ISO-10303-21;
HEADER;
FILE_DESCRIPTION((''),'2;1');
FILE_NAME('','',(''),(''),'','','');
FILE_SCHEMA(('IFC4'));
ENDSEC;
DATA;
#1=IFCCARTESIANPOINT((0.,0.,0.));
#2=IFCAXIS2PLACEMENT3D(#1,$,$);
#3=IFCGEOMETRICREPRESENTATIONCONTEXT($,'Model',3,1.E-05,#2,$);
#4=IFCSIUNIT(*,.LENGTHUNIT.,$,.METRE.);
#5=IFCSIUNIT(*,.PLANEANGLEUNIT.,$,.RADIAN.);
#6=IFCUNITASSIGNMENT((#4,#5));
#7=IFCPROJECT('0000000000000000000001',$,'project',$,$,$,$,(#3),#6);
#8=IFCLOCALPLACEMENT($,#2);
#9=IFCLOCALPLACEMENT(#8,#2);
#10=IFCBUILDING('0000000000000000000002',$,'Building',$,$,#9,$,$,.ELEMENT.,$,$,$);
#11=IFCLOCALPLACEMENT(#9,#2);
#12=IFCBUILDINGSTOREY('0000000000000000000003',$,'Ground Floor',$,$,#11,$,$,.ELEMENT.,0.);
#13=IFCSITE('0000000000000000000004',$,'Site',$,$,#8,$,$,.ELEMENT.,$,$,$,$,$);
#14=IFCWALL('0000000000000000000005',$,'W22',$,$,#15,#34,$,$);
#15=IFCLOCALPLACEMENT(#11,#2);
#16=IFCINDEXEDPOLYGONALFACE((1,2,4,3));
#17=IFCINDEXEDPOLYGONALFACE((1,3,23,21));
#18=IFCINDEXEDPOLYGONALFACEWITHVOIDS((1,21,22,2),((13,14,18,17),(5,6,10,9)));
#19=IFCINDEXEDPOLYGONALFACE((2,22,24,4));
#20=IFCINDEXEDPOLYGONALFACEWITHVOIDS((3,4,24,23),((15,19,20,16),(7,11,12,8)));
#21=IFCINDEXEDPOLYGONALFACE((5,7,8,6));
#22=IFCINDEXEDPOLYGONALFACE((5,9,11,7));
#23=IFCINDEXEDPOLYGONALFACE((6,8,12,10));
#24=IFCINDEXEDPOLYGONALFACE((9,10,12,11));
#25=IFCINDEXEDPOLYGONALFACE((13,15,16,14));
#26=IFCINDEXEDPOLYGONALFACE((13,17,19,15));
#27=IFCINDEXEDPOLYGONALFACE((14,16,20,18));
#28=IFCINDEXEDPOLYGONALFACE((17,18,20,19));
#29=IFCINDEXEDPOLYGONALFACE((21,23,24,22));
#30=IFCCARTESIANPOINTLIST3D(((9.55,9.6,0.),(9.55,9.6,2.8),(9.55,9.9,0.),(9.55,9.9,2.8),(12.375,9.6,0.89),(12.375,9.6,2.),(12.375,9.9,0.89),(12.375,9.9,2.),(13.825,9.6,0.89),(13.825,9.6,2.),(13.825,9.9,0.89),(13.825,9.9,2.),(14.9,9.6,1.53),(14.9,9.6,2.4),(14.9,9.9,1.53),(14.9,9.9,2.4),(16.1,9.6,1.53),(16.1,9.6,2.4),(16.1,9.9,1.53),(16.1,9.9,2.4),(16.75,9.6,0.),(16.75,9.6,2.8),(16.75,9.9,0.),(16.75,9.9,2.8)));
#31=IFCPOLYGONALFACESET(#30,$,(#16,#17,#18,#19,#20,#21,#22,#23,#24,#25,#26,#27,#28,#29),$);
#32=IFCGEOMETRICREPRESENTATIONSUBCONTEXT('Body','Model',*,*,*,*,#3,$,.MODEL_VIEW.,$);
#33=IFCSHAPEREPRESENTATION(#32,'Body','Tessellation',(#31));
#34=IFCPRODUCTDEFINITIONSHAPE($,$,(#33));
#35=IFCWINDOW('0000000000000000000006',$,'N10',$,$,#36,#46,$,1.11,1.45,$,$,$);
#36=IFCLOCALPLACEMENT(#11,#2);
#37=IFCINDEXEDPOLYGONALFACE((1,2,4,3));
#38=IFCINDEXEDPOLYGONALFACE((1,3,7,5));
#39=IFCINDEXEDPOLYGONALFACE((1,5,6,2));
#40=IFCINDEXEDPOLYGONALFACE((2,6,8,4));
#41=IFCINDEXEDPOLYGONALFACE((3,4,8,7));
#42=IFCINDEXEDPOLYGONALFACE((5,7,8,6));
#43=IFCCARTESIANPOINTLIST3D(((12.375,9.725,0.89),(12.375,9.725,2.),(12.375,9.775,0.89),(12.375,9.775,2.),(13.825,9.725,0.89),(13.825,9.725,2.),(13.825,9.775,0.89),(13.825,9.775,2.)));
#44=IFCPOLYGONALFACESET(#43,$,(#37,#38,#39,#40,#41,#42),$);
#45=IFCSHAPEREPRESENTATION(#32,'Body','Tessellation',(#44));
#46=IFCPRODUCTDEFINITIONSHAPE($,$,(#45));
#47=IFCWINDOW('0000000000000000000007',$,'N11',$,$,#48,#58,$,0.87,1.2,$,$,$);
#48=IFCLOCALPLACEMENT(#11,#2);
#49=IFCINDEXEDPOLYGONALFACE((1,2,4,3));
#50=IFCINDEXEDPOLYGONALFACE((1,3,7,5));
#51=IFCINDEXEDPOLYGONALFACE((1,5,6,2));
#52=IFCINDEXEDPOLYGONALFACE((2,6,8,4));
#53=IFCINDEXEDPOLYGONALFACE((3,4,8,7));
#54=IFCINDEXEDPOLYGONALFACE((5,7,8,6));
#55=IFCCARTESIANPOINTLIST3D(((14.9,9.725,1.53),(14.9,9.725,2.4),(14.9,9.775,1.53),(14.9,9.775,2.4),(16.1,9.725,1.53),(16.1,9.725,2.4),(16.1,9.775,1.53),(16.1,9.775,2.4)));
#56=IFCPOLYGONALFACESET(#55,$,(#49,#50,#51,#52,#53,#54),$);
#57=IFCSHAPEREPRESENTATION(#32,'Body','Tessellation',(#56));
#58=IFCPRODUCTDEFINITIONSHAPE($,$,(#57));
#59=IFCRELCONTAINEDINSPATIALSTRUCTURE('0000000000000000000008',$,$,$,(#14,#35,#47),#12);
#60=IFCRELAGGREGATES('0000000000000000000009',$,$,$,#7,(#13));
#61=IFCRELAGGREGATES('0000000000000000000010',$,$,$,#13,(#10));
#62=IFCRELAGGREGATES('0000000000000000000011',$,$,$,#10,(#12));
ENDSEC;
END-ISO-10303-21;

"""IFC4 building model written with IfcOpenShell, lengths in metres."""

from ifc_helpers import new_model, si_unit, frame, frame_2d, origin, origin_2d, place, context, subcontext, project, spatial, rectangle, extrude, element, fill, save


model = new_model("IFC4")

# Units and contexts
model_context = context("Model", 3, precision=1e-05, world=origin())
body_context = subcontext(model_context, "Body", "Model", "MODEL_VIEW")
ifc_project = project(units=[si_unit("LENGTHUNIT", "METRE"), si_unit("PLANEANGLEUNIT", "RADIAN")], contexts=[model_context])

# Site, building, storey
site_placement = place(None, origin())
site = spatial("IfcSite", under=ifc_project, at=site_placement, Name="Site", CompositionType="ELEMENT")
building_placement = place(site_placement, origin())
building = spatial("IfcBuilding", under=site, at=building_placement, Name="Building", CompositionType="ELEMENT")
storey_placement = place(building_placement, origin())
storey = spatial("IfcBuildingStorey", under=building, at=storey_placement, Name="Ground Floor", CompositionType="ELEMENT", Elevation=0.0)

# Wall, openings, windows
wall_1_placement = place(storey_placement, frame((9.7, 9.75, 0.0), x_axis=(1.0, 0.0, 0.0)))
wall_1 = element("IfcWall", 1, at=wall_1_placement, inside=storey, Name="W22", context=body_context, shape_type="SweptSolid", body=[
    extrude(rectangle(XDim=7.2, YDim=0.3, at=frame_2d((3.45, 0.0))), origin(), (0.0, 0.0, 1.0), 2.8),
])
opening_1_placement = place(wall_1_placement, frame((3.4, 0.0, 0.89)))
opening_1 = element("IfcOpeningElement", 2, at=opening_1_placement, cuts=wall_1, context=body_context, shape_type="SweptSolid", body=[
    extrude(rectangle(XDim=1.45, YDim=0.4, at=origin_2d()), origin(), (0.0, 0.0, 1.0), 1.11),
])
opening_2_placement = place(wall_1_placement, frame((5.8, 0.0, 1.53)))
opening_2 = element("IfcOpeningElement", 3, at=opening_2_placement, cuts=wall_1, context=body_context, shape_type="SweptSolid", body=[
    extrude(rectangle(XDim=1.2, YDim=0.4, at=origin_2d()), origin(), (0.0, 0.0, 1.0), 0.87),
])
window_1_placement = place(opening_1_placement, origin())
window_1 = element("IfcWindow", 4, at=window_1_placement, inside=storey, Name="N10", OverallHeight=1.11, OverallWidth=1.45, context=body_context, shape_type="SweptSolid", body=[
    extrude(rectangle(XDim=1.45, YDim=0.05, at=origin_2d()), origin(), (0.0, 0.0, 1.0), 1.11),
])
fill(opening_1, window_1)
window_2_placement = place(opening_2_placement, origin())
window_2 = element("IfcWindow", 5, at=window_2_placement, inside=storey, Name="N11", OverallHeight=0.87, OverallWidth=1.2, context=body_context, shape_type="SweptSolid", body=[
    extrude(rectangle(XDim=1.2, YDim=0.05, at=origin_2d()), origin(), (0.0, 0.0, 1.0), 0.87),
])
fill(opening_2, window_2)

save(model, "model.ifc")
